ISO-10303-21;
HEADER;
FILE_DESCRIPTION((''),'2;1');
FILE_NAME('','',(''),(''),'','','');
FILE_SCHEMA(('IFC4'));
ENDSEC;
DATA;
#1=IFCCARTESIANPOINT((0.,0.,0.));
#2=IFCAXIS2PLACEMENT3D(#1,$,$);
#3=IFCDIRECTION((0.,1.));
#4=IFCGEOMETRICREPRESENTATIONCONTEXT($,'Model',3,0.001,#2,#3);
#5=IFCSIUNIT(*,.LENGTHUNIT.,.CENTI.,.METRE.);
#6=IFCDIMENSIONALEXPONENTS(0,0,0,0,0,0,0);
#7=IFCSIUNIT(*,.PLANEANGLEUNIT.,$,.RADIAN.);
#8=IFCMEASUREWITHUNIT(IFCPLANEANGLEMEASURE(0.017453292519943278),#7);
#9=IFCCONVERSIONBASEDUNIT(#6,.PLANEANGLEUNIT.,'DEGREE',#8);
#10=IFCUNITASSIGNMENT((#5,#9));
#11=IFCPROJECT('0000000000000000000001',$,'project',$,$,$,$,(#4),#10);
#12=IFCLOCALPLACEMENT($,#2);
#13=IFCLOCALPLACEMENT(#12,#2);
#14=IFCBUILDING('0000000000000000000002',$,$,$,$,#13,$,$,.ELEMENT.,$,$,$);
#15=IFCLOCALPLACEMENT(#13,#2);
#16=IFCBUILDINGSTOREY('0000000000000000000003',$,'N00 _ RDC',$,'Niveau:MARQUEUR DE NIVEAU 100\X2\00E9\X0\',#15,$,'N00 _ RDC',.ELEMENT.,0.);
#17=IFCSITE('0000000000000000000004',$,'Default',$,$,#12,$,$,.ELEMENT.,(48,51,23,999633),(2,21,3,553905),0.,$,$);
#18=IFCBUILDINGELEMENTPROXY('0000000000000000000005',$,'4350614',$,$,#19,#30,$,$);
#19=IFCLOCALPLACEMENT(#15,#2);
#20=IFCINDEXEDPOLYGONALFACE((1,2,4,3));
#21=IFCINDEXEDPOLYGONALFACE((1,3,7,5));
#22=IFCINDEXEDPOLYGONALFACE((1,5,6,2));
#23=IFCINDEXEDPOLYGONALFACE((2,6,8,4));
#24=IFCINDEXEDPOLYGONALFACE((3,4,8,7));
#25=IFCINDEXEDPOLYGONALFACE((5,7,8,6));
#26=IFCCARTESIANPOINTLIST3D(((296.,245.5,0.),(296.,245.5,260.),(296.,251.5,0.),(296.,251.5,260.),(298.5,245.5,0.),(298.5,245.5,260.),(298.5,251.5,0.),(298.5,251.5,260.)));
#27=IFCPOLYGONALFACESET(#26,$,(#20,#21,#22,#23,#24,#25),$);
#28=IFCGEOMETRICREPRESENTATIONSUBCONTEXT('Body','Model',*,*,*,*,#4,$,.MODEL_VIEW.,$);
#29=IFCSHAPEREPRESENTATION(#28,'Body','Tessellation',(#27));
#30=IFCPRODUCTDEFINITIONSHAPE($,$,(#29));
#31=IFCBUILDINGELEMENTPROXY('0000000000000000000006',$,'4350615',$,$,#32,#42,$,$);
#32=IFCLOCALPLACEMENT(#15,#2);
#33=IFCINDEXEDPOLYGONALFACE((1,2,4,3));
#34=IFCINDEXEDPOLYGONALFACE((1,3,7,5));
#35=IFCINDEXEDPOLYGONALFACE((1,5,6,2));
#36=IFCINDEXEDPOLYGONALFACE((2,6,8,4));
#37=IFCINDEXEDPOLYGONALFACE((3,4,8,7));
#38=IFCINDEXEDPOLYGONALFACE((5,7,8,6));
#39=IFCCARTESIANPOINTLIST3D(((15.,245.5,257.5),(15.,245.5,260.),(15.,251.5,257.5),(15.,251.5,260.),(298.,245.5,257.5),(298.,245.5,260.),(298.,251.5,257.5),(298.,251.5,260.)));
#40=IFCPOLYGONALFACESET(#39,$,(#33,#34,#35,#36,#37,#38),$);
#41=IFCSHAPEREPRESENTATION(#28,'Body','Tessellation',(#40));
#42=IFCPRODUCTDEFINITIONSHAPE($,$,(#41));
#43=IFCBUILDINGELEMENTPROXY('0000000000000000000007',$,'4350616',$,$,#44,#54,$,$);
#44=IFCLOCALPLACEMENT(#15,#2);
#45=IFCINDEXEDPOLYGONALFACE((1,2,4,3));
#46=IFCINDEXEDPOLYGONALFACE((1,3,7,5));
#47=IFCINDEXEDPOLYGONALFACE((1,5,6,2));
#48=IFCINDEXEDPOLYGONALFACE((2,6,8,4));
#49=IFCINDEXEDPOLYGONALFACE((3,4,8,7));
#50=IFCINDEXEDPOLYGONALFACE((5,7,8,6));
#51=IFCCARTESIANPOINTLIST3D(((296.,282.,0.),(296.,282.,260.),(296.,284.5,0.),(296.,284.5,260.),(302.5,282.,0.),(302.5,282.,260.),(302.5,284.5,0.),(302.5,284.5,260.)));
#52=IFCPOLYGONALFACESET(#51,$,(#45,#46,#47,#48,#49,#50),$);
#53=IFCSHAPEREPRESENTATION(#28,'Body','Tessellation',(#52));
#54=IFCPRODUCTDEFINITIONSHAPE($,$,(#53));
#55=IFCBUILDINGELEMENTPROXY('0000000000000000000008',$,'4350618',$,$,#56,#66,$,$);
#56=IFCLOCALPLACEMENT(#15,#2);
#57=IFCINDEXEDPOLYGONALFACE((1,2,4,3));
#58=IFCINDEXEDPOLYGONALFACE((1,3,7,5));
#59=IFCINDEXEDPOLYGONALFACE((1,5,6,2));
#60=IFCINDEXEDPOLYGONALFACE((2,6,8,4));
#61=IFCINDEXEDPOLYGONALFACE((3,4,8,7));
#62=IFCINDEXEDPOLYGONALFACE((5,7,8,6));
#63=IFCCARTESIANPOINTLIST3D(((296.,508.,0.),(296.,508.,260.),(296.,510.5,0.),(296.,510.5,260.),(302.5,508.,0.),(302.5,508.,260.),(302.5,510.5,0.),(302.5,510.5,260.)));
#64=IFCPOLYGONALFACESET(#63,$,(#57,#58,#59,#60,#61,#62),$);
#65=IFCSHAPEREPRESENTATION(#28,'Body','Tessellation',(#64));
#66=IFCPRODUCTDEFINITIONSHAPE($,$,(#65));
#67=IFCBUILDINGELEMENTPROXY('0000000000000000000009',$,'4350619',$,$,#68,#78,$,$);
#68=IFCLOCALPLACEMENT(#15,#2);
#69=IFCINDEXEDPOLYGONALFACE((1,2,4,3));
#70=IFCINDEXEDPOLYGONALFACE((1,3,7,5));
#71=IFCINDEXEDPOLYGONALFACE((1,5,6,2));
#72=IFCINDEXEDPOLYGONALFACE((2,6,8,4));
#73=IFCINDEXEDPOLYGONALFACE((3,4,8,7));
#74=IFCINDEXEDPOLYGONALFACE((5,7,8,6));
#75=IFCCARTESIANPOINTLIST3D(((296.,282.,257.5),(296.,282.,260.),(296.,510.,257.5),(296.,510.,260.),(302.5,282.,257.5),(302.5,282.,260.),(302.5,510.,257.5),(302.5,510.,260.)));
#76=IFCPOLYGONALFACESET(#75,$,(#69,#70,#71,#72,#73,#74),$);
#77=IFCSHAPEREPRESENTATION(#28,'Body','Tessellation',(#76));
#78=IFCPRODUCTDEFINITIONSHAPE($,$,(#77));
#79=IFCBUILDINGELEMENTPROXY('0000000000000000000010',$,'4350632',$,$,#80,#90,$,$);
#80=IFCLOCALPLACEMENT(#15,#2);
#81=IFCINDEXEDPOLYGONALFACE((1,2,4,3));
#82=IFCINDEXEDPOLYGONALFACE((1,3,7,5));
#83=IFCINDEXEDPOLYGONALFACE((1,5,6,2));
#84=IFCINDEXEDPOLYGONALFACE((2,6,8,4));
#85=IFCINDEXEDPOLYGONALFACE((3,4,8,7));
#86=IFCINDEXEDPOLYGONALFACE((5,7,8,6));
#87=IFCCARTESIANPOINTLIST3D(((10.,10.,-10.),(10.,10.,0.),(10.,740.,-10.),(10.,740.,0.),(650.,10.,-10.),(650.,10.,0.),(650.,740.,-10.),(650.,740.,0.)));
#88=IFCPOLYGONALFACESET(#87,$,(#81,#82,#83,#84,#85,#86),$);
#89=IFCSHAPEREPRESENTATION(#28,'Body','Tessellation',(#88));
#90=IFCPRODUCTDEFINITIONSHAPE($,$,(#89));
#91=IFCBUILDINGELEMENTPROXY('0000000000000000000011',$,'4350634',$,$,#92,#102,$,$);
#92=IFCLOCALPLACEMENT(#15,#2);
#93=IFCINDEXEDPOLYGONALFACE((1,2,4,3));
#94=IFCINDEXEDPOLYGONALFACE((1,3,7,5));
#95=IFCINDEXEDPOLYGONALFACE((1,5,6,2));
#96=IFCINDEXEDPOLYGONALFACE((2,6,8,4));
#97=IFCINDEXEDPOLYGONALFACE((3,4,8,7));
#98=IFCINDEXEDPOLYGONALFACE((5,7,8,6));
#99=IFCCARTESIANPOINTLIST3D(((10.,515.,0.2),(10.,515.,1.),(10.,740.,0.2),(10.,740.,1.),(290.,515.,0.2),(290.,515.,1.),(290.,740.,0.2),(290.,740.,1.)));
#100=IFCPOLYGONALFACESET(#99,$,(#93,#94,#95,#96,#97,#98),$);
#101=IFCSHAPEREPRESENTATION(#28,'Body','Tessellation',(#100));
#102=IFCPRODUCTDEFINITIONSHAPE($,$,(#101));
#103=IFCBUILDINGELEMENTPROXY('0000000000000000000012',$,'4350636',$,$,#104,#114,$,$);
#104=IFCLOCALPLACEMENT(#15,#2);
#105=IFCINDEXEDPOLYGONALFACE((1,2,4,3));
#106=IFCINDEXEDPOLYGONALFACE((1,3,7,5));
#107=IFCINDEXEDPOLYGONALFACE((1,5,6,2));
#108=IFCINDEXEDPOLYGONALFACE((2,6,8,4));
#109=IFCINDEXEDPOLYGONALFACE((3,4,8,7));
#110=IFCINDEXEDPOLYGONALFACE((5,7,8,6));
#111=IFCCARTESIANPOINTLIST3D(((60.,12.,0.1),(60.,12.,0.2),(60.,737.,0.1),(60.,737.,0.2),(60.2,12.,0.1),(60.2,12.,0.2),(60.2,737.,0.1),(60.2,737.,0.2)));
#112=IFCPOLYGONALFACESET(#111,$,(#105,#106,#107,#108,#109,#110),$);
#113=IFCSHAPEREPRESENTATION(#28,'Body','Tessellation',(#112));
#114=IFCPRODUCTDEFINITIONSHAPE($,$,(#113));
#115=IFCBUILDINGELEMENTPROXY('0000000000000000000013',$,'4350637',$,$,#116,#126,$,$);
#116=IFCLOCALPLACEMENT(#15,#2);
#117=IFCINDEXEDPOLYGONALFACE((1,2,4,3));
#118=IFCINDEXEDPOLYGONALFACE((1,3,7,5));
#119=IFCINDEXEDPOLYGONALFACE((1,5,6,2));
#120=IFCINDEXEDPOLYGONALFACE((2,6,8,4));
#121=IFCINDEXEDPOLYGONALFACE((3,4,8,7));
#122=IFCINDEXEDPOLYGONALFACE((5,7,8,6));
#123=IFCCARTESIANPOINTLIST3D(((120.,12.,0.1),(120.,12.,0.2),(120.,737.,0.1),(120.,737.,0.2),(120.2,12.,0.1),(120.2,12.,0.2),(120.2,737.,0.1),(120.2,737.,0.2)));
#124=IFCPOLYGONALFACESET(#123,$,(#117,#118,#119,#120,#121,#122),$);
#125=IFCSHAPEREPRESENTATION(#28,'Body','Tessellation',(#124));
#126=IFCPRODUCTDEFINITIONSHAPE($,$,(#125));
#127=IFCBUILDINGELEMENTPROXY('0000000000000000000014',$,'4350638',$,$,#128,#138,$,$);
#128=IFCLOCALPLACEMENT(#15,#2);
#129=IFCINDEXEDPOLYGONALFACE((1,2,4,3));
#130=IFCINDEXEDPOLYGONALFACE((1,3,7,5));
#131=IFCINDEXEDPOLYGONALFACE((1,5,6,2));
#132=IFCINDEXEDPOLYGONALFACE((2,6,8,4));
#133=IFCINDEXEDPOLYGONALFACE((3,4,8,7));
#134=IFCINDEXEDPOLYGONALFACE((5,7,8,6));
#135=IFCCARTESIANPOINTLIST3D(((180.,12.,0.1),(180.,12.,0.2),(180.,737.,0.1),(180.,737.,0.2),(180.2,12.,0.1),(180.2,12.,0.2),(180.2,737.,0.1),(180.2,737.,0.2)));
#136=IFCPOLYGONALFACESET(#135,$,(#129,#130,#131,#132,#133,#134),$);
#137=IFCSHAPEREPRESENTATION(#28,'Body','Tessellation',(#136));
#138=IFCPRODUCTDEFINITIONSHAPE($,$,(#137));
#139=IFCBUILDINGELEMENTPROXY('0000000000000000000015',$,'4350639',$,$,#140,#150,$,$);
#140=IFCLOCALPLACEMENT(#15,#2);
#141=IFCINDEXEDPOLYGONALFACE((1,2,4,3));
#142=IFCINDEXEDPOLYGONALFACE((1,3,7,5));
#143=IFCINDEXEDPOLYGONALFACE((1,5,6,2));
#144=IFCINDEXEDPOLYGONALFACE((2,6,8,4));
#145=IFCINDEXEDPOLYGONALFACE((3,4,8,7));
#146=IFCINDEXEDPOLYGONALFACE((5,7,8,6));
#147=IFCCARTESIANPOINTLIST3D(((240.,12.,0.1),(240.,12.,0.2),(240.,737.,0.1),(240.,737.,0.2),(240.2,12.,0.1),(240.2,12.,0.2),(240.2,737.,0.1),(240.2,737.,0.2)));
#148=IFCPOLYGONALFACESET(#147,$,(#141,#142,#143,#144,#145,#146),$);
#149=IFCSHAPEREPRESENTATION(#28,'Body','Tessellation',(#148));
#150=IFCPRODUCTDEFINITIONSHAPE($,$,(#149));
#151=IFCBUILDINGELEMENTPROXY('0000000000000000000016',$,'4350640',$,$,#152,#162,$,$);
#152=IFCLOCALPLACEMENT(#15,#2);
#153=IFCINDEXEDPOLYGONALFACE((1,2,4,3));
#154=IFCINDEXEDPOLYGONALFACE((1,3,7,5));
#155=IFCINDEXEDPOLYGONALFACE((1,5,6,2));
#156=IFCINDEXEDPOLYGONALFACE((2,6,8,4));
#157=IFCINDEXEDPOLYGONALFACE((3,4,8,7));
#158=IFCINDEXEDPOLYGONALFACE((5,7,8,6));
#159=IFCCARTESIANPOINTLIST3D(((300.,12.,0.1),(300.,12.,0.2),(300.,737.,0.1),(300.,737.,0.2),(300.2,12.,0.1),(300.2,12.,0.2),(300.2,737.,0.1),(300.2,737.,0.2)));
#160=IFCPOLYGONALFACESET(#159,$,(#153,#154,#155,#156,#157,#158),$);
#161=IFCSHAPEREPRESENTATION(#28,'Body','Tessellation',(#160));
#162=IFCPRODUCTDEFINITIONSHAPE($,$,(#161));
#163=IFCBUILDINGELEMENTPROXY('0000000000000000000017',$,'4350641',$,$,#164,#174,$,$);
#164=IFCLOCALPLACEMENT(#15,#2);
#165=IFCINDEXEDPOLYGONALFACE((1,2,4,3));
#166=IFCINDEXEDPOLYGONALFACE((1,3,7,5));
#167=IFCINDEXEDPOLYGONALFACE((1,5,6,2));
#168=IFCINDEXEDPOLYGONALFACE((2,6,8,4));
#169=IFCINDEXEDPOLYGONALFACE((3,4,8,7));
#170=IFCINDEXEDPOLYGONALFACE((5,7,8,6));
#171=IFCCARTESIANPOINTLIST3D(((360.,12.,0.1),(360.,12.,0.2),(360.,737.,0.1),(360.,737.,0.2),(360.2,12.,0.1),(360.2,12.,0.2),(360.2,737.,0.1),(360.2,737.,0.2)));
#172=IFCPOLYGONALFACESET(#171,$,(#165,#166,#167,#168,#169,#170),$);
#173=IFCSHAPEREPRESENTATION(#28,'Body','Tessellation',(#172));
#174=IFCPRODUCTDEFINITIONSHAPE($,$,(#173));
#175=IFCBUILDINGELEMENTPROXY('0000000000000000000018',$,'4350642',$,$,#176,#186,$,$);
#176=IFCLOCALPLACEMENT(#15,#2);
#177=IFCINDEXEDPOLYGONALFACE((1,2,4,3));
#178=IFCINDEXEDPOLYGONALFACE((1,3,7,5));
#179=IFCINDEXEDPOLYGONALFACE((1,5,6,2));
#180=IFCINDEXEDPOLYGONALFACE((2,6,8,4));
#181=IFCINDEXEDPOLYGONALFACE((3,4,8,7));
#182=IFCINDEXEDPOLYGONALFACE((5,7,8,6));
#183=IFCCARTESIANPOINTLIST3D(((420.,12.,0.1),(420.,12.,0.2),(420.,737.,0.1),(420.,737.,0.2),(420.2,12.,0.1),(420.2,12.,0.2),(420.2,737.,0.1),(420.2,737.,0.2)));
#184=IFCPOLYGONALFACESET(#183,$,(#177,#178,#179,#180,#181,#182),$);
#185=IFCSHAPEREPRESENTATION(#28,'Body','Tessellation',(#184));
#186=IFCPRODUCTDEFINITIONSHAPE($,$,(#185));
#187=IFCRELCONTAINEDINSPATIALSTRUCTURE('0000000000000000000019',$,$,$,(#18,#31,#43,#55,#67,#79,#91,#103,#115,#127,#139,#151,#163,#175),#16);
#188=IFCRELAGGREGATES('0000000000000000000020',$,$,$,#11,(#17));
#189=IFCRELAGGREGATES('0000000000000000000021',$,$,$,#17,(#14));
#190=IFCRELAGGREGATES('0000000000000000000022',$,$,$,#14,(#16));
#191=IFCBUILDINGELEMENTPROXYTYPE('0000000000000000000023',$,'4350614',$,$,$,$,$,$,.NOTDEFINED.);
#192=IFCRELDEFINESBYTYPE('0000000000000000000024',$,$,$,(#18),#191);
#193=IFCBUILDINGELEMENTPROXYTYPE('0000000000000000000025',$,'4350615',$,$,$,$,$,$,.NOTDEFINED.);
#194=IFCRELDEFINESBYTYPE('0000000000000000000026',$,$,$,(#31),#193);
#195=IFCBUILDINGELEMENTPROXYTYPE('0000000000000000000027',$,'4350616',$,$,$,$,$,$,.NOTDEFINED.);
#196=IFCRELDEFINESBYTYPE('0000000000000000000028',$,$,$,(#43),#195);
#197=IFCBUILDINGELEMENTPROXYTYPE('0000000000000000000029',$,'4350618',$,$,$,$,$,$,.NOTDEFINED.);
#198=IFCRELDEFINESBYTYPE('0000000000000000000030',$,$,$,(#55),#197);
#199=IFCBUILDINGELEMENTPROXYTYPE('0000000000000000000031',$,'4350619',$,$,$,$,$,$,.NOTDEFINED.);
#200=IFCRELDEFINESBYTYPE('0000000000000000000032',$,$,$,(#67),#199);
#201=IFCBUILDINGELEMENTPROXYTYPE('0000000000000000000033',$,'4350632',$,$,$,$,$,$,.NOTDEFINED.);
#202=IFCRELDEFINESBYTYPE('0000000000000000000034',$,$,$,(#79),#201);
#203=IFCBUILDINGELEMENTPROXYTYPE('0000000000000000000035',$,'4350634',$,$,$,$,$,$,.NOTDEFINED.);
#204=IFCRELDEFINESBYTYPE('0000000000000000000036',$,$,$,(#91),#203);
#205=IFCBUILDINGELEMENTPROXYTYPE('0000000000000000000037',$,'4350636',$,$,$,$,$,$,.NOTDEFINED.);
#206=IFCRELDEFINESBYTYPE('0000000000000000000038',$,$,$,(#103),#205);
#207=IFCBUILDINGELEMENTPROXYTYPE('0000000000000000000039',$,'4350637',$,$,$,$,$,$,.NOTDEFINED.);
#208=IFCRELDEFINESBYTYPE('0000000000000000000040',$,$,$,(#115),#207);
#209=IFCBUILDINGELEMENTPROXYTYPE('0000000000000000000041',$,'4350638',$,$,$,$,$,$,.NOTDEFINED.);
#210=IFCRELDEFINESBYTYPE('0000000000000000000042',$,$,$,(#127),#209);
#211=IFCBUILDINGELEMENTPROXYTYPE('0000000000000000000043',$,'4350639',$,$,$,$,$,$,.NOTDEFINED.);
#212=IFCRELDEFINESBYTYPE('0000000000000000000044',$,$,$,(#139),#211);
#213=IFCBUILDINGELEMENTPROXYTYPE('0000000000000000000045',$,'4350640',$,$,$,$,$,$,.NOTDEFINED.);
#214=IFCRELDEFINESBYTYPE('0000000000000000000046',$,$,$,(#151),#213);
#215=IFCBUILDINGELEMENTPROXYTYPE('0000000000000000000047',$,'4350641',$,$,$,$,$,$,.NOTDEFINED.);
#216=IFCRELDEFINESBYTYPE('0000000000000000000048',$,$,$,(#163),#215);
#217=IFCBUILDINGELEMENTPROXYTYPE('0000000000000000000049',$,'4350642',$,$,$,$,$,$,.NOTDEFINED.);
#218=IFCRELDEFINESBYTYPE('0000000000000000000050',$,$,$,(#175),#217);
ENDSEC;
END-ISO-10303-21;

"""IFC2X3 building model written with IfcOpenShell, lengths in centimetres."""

from ifc_helpers import new_model, entity, si_unit, converted_unit, direction, frame, frame_2d, origin, origin_2d_with_axis, place, context, subcontext, project, spatial, rectangle, extrude, type_object, element, save


model = new_model("IFC2X3")

# Units and contexts
model_context = context("Model", 3, precision=0.001, world=origin(), true_north=direction((0.0, 1.0)))
body_context = subcontext(model_context, "Body", "Model", "MODEL_VIEW")
ifc_project = project(units=[si_unit("LENGTHUNIT", "METRE", prefix="CENTI"), converted_unit("PLANEANGLEUNIT", "DEGREE", entity("IfcPlaneAngleMeasure", 0.017453292519943278), si_unit("PLANEANGLEUNIT", "RADIAN"), dimensions=[0, 0, 0, 0, 0, 0, 0])], contexts=[model_context])

# Site, building, storey
site_placement = place(None, origin())
site = spatial("IfcSite", under=ifc_project, at=site_placement, Name="Default", CompositionType="ELEMENT", RefLatitude=(48, 51, 23, 999633), RefLongitude=(2, 21, 3, 553905), RefElevation=0.0)
building_placement = place(site_placement, origin())
building = spatial("IfcBuilding", under=site, at=building_placement, CompositionType="ELEMENT")
storey_placement = place(building_placement, origin())
storey = spatial("IfcBuildingStorey", under=building, at=storey_placement, Name="N00 _ RDC", ObjectType="Niveau:MARQUEUR DE NIVEAU 100é", LongName="N00 _ RDC", CompositionType="ELEMENT", Elevation=0.0)

# Building element proxies
building_element_proxy_type_1 = type_object("IfcBuildingElementProxyType", Name="4350614", PredefinedType="NOTDEFINED")
proxy_1_placement = place(storey_placement, origin())
element("IfcBuildingElementProxy", 1, at=proxy_1_placement, inside=storey, type_object=building_element_proxy_type_1, Name="4350614", context=body_context, shape_type="SweptSolid", body=[
    extrude(rectangle(XDim=2.5, YDim=6.0, at=frame_2d((0.0, 0.0), x_axis=(1.0, 0.0))), frame((297.25, 248.5, 0.0)), (0.0, 0.0, 1.0), 260.0),
])
building_element_proxy_type_2 = type_object("IfcBuildingElementProxyType", Name="4350615", PredefinedType="NOTDEFINED")
proxy_2_placement = place(storey_placement, origin())
element("IfcBuildingElementProxy", 2, at=proxy_2_placement, inside=storey, type_object=building_element_proxy_type_2, Name="4350615", context=body_context, shape_type="SweptSolid", body=[
    extrude(rectangle(XDim=283.0, YDim=6.0, at=frame_2d((0.0, 0.0), x_axis=(1.0, 0.0))), frame((156.5, 248.5, 257.5)), (0.0, 0.0, 1.0), 2.5),
])
building_element_proxy_type_3 = type_object("IfcBuildingElementProxyType", Name="4350616", PredefinedType="NOTDEFINED")
proxy_3_placement = place(storey_placement, origin())
element("IfcBuildingElementProxy", 3, at=proxy_3_placement, inside=storey, type_object=building_element_proxy_type_3, Name="4350616", context=body_context, shape_type="SweptSolid", body=[
    extrude(rectangle(XDim=6.5, YDim=2.5, at=frame_2d((0.0, 0.0), x_axis=(1.0, 0.0))), frame((299.25, 283.25, 0.0)), (0.0, 0.0, 1.0), 260.0),
])
building_element_proxy_type_4 = type_object("IfcBuildingElementProxyType", Name="4350618", PredefinedType="NOTDEFINED")
proxy_4_placement = place(storey_placement, origin())
element("IfcBuildingElementProxy", 4, at=proxy_4_placement, inside=storey, type_object=building_element_proxy_type_4, Name="4350618", context=body_context, shape_type="SweptSolid", body=[
    extrude(rectangle(XDim=6.5, YDim=2.5, at=frame_2d((0.0, 0.0), x_axis=(1.0, 0.0))), frame((299.25, 509.25, 0.0)), (0.0, 0.0, 1.0), 260.0),
])
building_element_proxy_type_5 = type_object("IfcBuildingElementProxyType", Name="4350619", PredefinedType="NOTDEFINED")
proxy_5_placement = place(storey_placement, origin())
element("IfcBuildingElementProxy", 5, at=proxy_5_placement, inside=storey, type_object=building_element_proxy_type_5, Name="4350619", context=body_context, shape_type="SweptSolid", body=[
    extrude(rectangle(XDim=6.5, YDim=228.0, at=frame_2d((0.0, 0.0), x_axis=(1.0, 0.0))), frame((299.25, 396.0, 257.5)), (0.0, 0.0, 1.0), 2.5),
])
building_element_proxy_type_6 = type_object("IfcBuildingElementProxyType", Name="4350632", PredefinedType="NOTDEFINED")
proxy_6_placement = place(storey_placement, origin())
element("IfcBuildingElementProxy", 6, at=proxy_6_placement, inside=storey, type_object=building_element_proxy_type_6, Name="4350632", context=body_context, shape_type="SweptSolid", body=[
    extrude(rectangle(XDim=640.0, YDim=730.0, at=origin_2d_with_axis()), frame((330.0, 375.0, -10.0)), (0.0, 0.0, 1.0), 10.0),
])
building_element_proxy_type_7 = type_object("IfcBuildingElementProxyType", Name="4350634", PredefinedType="NOTDEFINED")
proxy_7_placement = place(storey_placement, origin())
element("IfcBuildingElementProxy", 7, at=proxy_7_placement, inside=storey, type_object=building_element_proxy_type_7, Name="4350634", context=body_context, shape_type="SweptSolid", body=[
    extrude(rectangle(XDim=280.0, YDim=225.0, at=frame_2d((0.0, 0.0), x_axis=(1.0, 0.0))), frame((150.0, 627.5, 0.2)), (0.0, 0.0, 1.0), 0.8),
])
building_element_proxy_type_8 = type_object("IfcBuildingElementProxyType", Name="4350636", PredefinedType="NOTDEFINED")
proxy_8_placement = place(storey_placement, origin())
element("IfcBuildingElementProxy", 8, at=proxy_8_placement, inside=storey, type_object=building_element_proxy_type_8, Name="4350636", context=body_context, shape_type="SweptSolid", body=[
    extrude(rectangle(XDim=0.2, YDim=725.0, at=frame_2d((0.0, 0.0), x_axis=(1.0, 0.0))), frame((60.1, 374.5, 0.1)), (0.0, 0.0, 1.0), 0.1),
])
building_element_proxy_type_9 = type_object("IfcBuildingElementProxyType", Name="4350637", PredefinedType="NOTDEFINED")
proxy_9_placement = place(storey_placement, origin())
element("IfcBuildingElementProxy", 9, at=proxy_9_placement, inside=storey, type_object=building_element_proxy_type_9, Name="4350637", context=body_context, shape_type="SweptSolid", body=[
    extrude(rectangle(XDim=0.2, YDim=725.0, at=frame_2d((0.0, 0.0), x_axis=(1.0, 0.0))), frame((120.1, 374.5, 0.1)), (0.0, 0.0, 1.0), 0.1),
])
building_element_proxy_type_10 = type_object("IfcBuildingElementProxyType", Name="4350638", PredefinedType="NOTDEFINED")
proxy_10_placement = place(storey_placement, origin())
element("IfcBuildingElementProxy", 10, at=proxy_10_placement, inside=storey, type_object=building_element_proxy_type_10, Name="4350638", context=body_context, shape_type="SweptSolid", body=[
    extrude(rectangle(XDim=0.2, YDim=725.0, at=origin_2d_with_axis()), frame((180.1, 374.5, 0.1)), (0.0, 0.0, 1.0), 0.1),
])
building_element_proxy_type_11 = type_object("IfcBuildingElementProxyType", Name="4350639", PredefinedType="NOTDEFINED")
proxy_11_placement = place(storey_placement, origin())
element("IfcBuildingElementProxy", 11, at=proxy_11_placement, inside=storey, type_object=building_element_proxy_type_11, Name="4350639", context=body_context, shape_type="SweptSolid", body=[
    extrude(rectangle(XDim=0.2, YDim=725.0, at=frame_2d((0.0, 0.0), x_axis=(1.0, 0.0))), frame((240.1, 374.5, 0.1)), (0.0, 0.0, 1.0), 0.1),
])
building_element_proxy_type_12 = type_object("IfcBuildingElementProxyType", Name="4350640", PredefinedType="NOTDEFINED")
proxy_12_placement = place(storey_placement, origin())
element("IfcBuildingElementProxy", 12, at=proxy_12_placement, inside=storey, type_object=building_element_proxy_type_12, Name="4350640", context=body_context, shape_type="SweptSolid", body=[
    extrude(rectangle(XDim=0.2, YDim=725.0, at=origin_2d_with_axis()), frame((300.1, 374.5, 0.1)), (0.0, 0.0, 1.0), 0.1),
])
building_element_proxy_type_13 = type_object("IfcBuildingElementProxyType", Name="4350641", PredefinedType="NOTDEFINED")
proxy_13_placement = place(storey_placement, origin())
element("IfcBuildingElementProxy", 13, at=proxy_13_placement, inside=storey, type_object=building_element_proxy_type_13, Name="4350641", context=body_context, shape_type="SweptSolid", body=[
    extrude(rectangle(XDim=0.2, YDim=725.0, at=origin_2d_with_axis()), frame((360.1, 374.5, 0.1)), (0.0, 0.0, 1.0), 0.1),
])
building_element_proxy_type_14 = type_object("IfcBuildingElementProxyType", Name="4350642", PredefinedType="NOTDEFINED")
proxy_14_placement = place(storey_placement, origin())
element("IfcBuildingElementProxy", 14, at=proxy_14_placement, inside=storey, type_object=building_element_proxy_type_14, Name="4350642", context=body_context, shape_type="SweptSolid", body=[
    extrude(rectangle(XDim=0.2, YDim=725.0, at=origin_2d_with_axis()), frame((420.1, 374.5, 0.1)), (0.0, 0.0, 1.0), 0.1),
])

save(model, "model.ifc")
